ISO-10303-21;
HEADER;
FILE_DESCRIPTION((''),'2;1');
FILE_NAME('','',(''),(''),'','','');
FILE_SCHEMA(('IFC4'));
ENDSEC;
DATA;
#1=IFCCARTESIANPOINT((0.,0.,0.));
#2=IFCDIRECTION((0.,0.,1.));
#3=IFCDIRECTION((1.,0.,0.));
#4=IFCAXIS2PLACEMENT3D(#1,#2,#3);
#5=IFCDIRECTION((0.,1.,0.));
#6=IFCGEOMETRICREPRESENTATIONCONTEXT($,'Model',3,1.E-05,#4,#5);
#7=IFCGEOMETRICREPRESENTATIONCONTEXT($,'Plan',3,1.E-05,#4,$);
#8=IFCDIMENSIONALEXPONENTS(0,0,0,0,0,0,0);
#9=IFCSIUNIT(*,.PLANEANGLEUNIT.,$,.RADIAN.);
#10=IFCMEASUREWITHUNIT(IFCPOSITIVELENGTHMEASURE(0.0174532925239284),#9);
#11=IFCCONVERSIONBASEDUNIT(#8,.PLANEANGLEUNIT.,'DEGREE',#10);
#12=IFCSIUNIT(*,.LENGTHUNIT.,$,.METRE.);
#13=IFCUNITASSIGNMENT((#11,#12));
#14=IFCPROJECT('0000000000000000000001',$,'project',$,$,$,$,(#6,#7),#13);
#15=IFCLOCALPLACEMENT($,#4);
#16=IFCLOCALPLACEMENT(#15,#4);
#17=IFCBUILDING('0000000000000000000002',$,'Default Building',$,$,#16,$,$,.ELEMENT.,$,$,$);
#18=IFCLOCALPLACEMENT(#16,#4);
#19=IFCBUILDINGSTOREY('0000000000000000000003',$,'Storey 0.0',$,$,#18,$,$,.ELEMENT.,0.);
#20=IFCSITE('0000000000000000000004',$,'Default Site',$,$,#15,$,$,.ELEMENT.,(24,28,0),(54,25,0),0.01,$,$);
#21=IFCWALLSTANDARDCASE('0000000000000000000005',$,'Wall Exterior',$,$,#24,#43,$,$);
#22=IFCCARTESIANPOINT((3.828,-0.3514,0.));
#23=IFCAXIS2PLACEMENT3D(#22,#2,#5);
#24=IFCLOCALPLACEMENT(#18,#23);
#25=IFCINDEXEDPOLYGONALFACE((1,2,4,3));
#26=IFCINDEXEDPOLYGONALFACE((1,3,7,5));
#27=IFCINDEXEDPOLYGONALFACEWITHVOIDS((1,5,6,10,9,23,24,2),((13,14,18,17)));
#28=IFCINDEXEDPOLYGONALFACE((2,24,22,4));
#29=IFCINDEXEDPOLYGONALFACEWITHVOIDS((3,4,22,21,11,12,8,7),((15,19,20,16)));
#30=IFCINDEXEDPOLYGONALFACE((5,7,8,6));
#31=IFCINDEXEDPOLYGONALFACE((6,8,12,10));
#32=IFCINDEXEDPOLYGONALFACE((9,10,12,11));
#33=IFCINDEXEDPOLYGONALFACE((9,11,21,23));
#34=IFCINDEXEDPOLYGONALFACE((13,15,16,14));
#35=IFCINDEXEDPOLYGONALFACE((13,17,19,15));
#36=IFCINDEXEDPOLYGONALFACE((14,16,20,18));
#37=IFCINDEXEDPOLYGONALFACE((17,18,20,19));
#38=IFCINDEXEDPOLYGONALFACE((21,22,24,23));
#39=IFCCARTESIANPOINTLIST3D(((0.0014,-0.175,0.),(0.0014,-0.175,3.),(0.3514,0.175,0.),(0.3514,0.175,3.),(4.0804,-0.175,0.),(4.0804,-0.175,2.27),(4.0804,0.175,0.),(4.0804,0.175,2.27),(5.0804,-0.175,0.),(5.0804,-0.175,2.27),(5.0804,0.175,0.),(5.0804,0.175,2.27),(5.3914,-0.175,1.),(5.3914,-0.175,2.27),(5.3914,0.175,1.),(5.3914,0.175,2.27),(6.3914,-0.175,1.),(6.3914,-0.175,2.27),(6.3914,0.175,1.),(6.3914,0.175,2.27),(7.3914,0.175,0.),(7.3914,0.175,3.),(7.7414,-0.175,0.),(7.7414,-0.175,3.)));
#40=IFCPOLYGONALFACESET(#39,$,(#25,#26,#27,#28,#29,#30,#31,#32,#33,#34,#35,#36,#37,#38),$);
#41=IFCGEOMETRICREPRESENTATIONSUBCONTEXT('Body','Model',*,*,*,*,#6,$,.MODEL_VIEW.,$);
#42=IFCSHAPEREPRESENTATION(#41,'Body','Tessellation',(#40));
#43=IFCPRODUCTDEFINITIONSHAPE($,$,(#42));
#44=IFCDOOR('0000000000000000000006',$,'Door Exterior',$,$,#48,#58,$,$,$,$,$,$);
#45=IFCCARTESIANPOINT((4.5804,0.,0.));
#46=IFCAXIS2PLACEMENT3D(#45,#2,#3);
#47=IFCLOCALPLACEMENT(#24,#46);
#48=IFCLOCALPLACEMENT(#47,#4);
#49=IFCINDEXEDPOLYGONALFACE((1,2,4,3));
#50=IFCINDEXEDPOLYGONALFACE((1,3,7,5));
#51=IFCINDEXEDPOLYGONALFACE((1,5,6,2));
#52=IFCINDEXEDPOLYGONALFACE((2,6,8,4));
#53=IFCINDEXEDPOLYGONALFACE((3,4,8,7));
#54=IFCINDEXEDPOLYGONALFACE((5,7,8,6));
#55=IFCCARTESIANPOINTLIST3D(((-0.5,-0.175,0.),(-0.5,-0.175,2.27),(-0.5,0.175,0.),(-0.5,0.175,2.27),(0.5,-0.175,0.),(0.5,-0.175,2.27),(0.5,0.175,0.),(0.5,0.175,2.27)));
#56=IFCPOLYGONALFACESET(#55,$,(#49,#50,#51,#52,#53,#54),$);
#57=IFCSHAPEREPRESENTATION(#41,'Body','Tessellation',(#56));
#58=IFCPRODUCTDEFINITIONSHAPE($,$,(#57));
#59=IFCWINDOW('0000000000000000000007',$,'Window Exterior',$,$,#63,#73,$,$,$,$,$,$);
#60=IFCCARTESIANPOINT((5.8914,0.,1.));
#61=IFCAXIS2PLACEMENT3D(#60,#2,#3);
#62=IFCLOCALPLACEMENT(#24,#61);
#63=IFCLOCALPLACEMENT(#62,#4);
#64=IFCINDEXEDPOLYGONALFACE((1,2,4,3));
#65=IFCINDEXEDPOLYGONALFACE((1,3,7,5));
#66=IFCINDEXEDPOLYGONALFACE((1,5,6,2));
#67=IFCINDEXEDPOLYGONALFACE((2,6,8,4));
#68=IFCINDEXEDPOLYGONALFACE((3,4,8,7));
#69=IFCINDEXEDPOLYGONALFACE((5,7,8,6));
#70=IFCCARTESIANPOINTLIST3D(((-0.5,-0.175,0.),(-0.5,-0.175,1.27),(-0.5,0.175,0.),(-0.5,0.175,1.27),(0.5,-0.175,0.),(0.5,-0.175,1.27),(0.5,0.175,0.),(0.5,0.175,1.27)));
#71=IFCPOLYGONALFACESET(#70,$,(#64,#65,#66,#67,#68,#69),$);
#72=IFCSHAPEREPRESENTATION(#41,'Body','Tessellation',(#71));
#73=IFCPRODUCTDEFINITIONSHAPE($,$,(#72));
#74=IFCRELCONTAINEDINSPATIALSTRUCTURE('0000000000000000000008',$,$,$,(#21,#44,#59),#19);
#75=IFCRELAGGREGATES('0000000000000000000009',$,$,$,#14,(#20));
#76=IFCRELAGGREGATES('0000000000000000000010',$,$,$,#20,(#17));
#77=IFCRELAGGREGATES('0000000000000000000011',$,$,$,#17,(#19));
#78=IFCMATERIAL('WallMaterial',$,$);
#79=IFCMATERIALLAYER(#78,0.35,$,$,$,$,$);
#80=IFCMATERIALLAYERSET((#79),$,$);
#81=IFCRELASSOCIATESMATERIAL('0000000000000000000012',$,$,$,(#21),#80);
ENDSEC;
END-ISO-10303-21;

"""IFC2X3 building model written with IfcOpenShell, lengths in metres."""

from ifc_helpers import new_model, entity, si_unit, converted_unit, direction, frame, origin_with_axes, place, context, subcontext, project, spatial, polyline, outline, extrude, material, layer, layer_set, layer_usage, element, fill, save


model = new_model("IFC2X3")

# Units and contexts
model_context = context("Model", 3, precision=1e-05, world=origin_with_axes(), true_north=direction((0.0, 1.0, 0.0)))
plan_context = context("Plan", 3, precision=1e-05, world=origin_with_axes())
body_context = subcontext(model_context, "Body", "Model", "MODEL_VIEW")
ifc_project = project(units=[converted_unit("PLANEANGLEUNIT", "DEGREE", entity("IfcPositiveLengthMeasure", 0.0174532925239284), si_unit("PLANEANGLEUNIT", "RADIAN"), dimensions=[0, 0, 0, 0, 0, 0, 0]), si_unit("LENGTHUNIT", "METRE")], contexts=[model_context, plan_context])

# Site, building, storey
site_placement = place(None, origin_with_axes())
site = spatial("IfcSite", under=ifc_project, at=site_placement, Name="Default Site", CompositionType="ELEMENT", RefLatitude=(24, 28, 0), RefLongitude=(54, 25, 0), RefElevation=0.01)
building_placement = place(site_placement, origin_with_axes())
building = spatial("IfcBuilding", under=site, at=building_placement, Name="Default Building", CompositionType="ELEMENT")
storey_placement = place(building_placement, origin_with_axes())
storey = spatial("IfcBuildingStorey", under=building, at=storey_placement, Name="Storey 0.0", CompositionType="ELEMENT", Elevation=0.0)

# Wall, openings, door, window
ifc_material_1 = material(Name="WallMaterial")
ifc_layer_1 = layer(ifc_material_1, 0.35)
ifc_layer_set_1 = layer_set([ifc_layer_1])
ifc_layer_usage_1 = layer_usage(ifc_layer_set_1, "AXIS2", "POSITIVE", -0.175)
wall_1_placement = place(storey_placement, frame((3.828, -0.3514, 0.0), z_axis=(0.0, 0.0, 1.0), x_axis=(0.0, 1.0, 0.0)))
wall_1 = element("IfcWallStandardCase", 1, at=wall_1_placement, inside=storey, material=ifc_layer_usage_1, Name="Wall Exterior", context=body_context, shape_type="SweptSolid", body=[
    extrude(outline(polyline([(7.7414, -0.175), (7.3914, 0.175), (0.3514, 0.175), (0.0014, -0.175), (7.7414, -0.175)])), origin_with_axes(), (0.0, 0.0, 1.0), 3.0),
])
opening_1_placement = place(wall_1_placement, frame((4.5804, 0.0, 0.0), z_axis=(0.0, 0.0, 1.0), x_axis=(1.0, 0.0, 0.0)))
opening_1 = element("IfcOpeningElement", 2, at=opening_1_placement, cuts=wall_1, context=body_context, shape_type="SweptSolid", body=[
    extrude(outline(polyline([(-0.5, 0.372), (0.5, 0.372), (0.5, -0.372), (-0.5, -0.372), (-0.5, 0.372)])), origin_with_axes(), (0.0, 0.0, 1.0), 2.27),
])
opening_2_placement = place(wall_1_placement, frame((5.8914, 0.0, 1.0), z_axis=(0.0, 0.0, 1.0), x_axis=(1.0, 0.0, 0.0)))
opening_2 = element("IfcOpeningElement", 3, at=opening_2_placement, cuts=wall_1, context=body_context, shape_type="SweptSolid", body=[
    extrude(outline(polyline([(-0.5, 0.372), (0.5, 0.372), (0.5, -0.372), (-0.5, -0.372), (-0.5, 0.372)])), origin_with_axes(), (0.0, 0.0, 1.0), 1.27),
])
door_1_placement = place(opening_1_placement, origin_with_axes())
door_1 = element("IfcDoor", 4, at=door_1_placement, inside=storey, Name="Door Exterior", context=body_context, shape_type="SweptSolid", body=[
    extrude(outline(polyline([(-0.5, 0.175), (0.5, 0.175), (0.5, -0.175), (-0.5, -0.175), (-0.5, 0.175)])), origin_with_axes(), (0.0, 0.0, 1.0), 2.27),
])
fill(opening_1, door_1)
window_1_placement = place(opening_2_placement, origin_with_axes())
window_1 = element("IfcWindow", 5, at=window_1_placement, inside=storey, Name="Window Exterior", context=body_context, shape_type="SweptSolid", body=[
    extrude(outline(polyline([(-0.5, 0.175), (0.5, 0.175), (0.5, -0.175), (-0.5, -0.175), (-0.5, 0.175)])), origin_with_axes(), (0.0, 0.0, 1.0), 1.27),
])
fill(opening_2, window_1)

save(model, "model.ifc")
